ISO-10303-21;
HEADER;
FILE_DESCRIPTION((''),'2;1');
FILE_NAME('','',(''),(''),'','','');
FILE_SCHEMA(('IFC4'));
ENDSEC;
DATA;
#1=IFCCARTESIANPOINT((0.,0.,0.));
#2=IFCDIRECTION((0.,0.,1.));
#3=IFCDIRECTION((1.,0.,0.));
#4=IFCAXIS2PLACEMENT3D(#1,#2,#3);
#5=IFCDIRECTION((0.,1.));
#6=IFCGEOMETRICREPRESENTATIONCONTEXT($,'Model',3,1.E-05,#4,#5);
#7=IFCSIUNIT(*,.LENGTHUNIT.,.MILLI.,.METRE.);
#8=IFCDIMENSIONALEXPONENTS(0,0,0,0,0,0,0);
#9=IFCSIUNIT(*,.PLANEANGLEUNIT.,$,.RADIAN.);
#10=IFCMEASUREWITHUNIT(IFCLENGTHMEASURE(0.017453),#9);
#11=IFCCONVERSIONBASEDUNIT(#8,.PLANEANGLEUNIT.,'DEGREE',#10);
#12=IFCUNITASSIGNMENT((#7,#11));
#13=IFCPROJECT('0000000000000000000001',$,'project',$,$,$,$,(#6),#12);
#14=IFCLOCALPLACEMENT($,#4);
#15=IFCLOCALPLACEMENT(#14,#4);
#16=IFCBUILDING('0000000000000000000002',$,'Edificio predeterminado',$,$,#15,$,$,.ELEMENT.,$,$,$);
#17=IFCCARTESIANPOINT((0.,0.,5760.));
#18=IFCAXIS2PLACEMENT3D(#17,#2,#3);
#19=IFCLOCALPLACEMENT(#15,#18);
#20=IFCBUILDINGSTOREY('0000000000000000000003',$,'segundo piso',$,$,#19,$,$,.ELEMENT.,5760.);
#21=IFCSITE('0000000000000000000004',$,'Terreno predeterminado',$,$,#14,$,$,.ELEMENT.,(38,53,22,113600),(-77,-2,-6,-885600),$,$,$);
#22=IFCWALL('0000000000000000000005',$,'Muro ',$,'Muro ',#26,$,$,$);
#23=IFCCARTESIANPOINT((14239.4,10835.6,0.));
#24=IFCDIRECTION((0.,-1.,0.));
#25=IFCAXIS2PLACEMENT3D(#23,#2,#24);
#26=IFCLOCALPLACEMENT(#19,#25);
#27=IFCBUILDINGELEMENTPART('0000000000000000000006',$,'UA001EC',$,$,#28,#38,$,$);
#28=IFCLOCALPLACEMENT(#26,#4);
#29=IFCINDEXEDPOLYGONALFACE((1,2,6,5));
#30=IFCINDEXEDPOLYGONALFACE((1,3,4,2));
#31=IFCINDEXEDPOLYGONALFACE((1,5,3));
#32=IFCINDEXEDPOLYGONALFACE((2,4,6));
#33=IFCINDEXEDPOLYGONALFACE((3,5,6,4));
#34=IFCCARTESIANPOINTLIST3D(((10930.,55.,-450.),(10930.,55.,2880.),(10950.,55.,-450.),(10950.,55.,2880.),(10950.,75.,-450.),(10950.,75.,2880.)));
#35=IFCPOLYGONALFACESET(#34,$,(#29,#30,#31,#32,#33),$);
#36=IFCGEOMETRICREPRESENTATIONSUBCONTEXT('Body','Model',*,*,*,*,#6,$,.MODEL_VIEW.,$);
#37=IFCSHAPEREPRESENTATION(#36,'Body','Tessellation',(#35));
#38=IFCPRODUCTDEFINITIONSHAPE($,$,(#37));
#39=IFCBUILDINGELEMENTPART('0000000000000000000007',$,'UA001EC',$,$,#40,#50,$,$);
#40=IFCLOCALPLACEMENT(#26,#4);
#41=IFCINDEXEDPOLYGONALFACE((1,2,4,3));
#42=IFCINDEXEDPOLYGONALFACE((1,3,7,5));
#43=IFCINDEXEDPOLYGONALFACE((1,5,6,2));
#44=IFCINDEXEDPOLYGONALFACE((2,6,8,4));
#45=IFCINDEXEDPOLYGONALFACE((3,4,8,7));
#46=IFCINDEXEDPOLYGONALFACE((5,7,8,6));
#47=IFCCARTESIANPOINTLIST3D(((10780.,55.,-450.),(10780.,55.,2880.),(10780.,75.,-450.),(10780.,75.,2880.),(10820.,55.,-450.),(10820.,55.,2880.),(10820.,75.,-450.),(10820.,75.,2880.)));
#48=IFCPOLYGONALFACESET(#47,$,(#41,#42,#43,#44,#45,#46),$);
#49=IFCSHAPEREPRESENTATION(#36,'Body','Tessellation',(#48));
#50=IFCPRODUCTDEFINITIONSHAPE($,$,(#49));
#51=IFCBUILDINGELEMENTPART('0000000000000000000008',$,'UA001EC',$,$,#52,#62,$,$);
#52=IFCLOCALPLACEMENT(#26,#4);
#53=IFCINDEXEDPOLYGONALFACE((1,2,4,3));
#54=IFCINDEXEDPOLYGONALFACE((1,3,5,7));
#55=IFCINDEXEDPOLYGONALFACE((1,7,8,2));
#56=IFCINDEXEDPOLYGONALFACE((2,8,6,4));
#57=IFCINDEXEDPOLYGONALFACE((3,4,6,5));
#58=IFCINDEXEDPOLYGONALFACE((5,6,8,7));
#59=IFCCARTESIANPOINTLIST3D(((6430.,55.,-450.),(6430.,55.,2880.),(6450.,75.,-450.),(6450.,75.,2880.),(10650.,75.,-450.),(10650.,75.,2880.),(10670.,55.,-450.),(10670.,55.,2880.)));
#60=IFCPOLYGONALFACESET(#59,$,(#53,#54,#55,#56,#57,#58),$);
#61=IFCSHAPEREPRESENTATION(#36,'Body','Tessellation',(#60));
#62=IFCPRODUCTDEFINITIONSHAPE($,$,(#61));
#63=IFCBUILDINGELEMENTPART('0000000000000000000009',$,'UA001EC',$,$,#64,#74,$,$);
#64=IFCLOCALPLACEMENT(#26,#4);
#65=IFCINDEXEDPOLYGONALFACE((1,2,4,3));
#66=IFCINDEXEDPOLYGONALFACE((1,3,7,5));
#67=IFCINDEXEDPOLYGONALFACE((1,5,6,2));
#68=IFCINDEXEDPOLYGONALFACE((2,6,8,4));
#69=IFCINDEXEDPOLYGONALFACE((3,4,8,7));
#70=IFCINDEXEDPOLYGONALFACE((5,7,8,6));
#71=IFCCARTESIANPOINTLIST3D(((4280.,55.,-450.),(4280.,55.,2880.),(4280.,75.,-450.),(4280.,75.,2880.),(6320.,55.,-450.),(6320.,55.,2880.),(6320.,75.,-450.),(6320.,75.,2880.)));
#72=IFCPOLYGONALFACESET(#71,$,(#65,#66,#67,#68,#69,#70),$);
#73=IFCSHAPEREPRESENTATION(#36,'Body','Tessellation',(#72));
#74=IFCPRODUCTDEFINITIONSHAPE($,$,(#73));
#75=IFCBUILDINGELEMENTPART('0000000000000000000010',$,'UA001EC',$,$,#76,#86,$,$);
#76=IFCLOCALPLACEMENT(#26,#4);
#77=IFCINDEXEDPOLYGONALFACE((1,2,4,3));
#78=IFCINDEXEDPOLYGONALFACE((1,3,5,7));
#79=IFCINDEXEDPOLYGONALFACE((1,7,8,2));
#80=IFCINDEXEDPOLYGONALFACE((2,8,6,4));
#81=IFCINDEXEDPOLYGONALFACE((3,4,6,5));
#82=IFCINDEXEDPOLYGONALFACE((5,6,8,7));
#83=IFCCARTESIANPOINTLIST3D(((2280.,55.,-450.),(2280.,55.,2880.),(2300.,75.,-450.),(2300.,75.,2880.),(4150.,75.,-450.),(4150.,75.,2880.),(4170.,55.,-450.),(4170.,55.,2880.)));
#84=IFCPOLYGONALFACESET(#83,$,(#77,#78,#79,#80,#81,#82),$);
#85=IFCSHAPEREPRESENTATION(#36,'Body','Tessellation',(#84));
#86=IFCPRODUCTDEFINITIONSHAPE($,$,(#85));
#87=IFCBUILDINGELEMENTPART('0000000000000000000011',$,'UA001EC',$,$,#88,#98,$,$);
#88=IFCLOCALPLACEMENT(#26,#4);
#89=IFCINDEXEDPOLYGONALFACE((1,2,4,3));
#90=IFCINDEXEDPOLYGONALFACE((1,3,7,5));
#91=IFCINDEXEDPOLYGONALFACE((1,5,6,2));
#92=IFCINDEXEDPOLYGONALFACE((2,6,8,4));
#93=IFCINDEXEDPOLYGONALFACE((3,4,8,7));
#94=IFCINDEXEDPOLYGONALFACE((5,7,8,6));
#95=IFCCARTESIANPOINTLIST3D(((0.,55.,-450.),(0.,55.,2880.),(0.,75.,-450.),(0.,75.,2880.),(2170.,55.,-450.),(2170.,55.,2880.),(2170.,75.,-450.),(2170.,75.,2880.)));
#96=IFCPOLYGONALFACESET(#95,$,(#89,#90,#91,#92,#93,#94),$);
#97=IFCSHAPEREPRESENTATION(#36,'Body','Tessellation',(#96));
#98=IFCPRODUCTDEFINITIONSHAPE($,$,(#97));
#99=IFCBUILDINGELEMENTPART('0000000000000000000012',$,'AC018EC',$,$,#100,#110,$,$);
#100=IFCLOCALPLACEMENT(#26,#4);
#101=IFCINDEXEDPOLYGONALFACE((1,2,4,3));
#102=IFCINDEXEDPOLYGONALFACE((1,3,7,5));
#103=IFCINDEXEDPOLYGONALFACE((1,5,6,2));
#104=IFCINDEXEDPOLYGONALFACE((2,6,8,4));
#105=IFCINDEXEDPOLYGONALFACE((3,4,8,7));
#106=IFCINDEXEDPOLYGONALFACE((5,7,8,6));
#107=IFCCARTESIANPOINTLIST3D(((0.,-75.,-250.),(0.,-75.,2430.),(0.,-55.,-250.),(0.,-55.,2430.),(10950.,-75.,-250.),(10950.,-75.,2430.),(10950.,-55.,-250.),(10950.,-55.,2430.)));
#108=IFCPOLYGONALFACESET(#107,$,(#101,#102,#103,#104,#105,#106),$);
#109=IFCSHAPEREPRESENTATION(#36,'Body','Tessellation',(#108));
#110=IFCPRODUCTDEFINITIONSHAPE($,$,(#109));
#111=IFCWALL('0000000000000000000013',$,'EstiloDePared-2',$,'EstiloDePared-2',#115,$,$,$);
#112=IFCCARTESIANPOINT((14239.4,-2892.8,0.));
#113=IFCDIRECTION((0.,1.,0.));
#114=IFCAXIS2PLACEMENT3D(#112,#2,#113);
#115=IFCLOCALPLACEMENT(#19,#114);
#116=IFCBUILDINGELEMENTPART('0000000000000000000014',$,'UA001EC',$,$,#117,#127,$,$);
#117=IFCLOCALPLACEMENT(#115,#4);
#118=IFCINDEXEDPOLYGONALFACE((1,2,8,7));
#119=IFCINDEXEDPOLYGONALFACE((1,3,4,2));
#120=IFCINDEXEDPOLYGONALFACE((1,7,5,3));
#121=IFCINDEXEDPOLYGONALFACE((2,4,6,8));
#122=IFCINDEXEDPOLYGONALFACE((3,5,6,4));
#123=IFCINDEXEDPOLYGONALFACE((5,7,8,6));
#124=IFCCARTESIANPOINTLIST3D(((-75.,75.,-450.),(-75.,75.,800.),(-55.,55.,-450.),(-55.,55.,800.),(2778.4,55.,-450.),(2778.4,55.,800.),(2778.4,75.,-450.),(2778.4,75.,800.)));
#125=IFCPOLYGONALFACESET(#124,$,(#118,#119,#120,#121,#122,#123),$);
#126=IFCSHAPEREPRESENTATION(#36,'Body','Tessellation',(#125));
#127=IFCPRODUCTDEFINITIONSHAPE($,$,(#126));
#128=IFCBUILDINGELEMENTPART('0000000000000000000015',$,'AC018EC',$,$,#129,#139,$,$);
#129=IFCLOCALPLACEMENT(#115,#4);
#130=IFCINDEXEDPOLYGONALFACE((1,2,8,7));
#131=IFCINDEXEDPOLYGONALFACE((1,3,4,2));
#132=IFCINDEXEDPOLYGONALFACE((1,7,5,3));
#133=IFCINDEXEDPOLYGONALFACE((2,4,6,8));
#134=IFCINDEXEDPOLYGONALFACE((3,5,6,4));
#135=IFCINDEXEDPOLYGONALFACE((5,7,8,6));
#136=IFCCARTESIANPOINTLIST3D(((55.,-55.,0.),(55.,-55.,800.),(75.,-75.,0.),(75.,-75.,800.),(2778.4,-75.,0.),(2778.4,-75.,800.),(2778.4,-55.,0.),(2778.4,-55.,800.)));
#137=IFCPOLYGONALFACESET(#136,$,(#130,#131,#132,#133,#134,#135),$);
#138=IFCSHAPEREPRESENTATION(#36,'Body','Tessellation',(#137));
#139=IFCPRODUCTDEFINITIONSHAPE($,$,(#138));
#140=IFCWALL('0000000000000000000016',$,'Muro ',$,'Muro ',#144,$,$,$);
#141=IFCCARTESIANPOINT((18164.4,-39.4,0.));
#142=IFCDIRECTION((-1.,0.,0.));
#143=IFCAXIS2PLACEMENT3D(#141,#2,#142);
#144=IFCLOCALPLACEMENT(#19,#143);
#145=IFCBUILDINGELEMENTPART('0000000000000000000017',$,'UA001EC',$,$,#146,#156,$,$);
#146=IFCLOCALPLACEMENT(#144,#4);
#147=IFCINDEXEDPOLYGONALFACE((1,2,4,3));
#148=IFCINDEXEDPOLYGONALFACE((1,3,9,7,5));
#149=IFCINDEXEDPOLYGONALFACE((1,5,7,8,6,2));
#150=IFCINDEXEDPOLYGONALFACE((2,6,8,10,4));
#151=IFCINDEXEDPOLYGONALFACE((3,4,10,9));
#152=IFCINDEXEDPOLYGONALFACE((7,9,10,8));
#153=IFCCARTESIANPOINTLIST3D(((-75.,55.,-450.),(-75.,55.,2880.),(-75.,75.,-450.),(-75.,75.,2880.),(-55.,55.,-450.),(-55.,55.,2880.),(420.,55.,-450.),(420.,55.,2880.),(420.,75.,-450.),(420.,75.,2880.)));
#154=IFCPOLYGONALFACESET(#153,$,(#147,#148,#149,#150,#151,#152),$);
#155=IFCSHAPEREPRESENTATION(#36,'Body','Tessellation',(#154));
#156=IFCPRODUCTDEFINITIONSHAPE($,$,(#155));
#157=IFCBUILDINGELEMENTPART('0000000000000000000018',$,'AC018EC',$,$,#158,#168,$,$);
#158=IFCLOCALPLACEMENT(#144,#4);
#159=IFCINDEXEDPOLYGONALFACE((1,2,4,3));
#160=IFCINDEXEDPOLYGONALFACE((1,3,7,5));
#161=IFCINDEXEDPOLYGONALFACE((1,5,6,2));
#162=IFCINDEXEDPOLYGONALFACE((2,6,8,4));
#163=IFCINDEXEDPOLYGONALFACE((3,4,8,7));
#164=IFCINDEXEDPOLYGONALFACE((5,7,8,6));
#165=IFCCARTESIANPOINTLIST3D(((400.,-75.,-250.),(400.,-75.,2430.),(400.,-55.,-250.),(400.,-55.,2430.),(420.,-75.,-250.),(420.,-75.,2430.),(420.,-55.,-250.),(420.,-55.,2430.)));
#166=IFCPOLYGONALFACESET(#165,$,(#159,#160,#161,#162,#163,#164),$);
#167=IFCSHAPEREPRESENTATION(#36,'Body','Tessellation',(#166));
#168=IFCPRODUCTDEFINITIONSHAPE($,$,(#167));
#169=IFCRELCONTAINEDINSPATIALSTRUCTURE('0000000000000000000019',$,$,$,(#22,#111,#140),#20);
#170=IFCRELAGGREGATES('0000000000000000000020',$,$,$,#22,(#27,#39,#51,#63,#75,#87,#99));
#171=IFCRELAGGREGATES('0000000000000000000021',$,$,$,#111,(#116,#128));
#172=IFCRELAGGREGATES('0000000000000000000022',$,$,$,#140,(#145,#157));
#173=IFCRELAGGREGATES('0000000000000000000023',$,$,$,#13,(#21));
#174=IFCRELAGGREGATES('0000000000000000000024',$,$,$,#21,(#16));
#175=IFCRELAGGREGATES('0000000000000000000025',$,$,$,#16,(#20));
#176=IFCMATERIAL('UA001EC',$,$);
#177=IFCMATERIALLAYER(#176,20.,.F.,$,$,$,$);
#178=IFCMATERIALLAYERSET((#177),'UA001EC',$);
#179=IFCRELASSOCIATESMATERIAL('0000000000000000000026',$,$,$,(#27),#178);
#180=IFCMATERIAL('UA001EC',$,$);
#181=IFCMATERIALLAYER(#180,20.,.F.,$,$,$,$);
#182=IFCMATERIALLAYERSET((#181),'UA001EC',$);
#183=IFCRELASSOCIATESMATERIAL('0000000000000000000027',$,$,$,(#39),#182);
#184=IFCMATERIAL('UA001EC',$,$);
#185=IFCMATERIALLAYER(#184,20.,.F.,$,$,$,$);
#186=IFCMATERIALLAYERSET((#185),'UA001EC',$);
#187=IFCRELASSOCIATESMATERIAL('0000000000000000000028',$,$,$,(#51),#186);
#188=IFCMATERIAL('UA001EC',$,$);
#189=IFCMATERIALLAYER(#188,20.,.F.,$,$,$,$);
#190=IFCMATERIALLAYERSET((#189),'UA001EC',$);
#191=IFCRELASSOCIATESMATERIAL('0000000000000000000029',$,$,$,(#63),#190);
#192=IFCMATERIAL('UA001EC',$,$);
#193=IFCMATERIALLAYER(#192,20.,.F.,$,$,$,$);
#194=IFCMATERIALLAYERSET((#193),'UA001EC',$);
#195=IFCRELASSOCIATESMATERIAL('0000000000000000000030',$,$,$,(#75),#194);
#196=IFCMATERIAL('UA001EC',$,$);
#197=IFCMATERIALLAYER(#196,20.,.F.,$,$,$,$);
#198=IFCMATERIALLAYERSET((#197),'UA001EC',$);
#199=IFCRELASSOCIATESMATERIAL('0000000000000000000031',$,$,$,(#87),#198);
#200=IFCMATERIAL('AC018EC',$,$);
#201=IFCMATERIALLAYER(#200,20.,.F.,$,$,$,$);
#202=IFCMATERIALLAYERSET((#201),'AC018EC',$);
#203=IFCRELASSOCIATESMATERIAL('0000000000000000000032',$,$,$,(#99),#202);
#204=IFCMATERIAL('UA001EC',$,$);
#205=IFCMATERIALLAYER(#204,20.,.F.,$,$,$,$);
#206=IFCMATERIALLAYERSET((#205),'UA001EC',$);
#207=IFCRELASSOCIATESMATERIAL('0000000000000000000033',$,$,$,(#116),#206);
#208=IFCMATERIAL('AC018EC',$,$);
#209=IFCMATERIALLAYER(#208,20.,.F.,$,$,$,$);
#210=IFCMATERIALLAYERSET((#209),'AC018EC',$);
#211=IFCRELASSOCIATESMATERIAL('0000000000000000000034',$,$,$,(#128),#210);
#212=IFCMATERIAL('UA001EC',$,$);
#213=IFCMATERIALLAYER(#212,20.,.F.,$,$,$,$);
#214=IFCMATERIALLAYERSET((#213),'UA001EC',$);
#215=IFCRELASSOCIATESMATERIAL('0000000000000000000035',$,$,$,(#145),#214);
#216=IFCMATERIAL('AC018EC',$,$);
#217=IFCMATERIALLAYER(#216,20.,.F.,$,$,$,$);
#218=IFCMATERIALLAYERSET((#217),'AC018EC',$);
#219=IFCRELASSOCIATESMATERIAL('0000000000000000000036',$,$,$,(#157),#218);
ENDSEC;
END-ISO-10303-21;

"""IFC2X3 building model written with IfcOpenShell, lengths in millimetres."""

from ifc_helpers import new_model, entity, si_unit, converted_unit, direction, frame, origin_with_axes, place, context, subcontext, project, spatial, polyline, outline, extrude, material, layer, layer_set, layer_usage, element, aggregate, save


model = new_model("IFC2X3")

# Units and contexts
model_context = context("Model", 3, precision=1e-05, world=origin_with_axes(), true_north=direction((0.0, 1.0)))
body_context = subcontext(model_context, "Body", "Model", "MODEL_VIEW")
ifc_project = project(units=[si_unit("LENGTHUNIT", "METRE", prefix="MILLI"), converted_unit("PLANEANGLEUNIT", "DEGREE", entity("IfcLengthMeasure", 0.017453), si_unit("PLANEANGLEUNIT", "RADIAN"), dimensions=[0, 0, 0, 0, 0, 0, 0])], contexts=[model_context])

# Site, building, storey
site_placement = place(None, origin_with_axes())
site = spatial("IfcSite", under=ifc_project, at=site_placement, Name="Terreno predeterminado", CompositionType="ELEMENT", RefLatitude=(38, 53, 22, 113600), RefLongitude=(-77, -2, -6, -885600))
building_placement = place(site_placement, origin_with_axes())
building = spatial("IfcBuilding", under=site, at=building_placement, Name="Edificio predeterminado", CompositionType="ELEMENT")
storey_placement = place(building_placement, frame((0.0, 0.0, 5760.0), z_axis=(0.0, 0.0, 1.0), x_axis=(1.0, 0.0, 0.0)))
storey = spatial("IfcBuildingStorey", under=building, at=storey_placement, Name="segundo piso", CompositionType="ELEMENT", Elevation=5760.0)

# Walls, building element parts
wall_1_placement = place(storey_placement, frame((14239.4, 10835.6, 0.0), z_axis=(0.0, 0.0, 1.0), x_axis=(0.0, -1.0, 0.0)))
wall_1 = element("IfcWall", 1, at=wall_1_placement, inside=storey, Name="Muro ", ObjectType="Muro ")
ifc_material_1 = material(Name="UA001EC")
ifc_layer_1 = layer(ifc_material_1, 20.0, ventilated=False)
ifc_layer_set_1 = layer_set([ifc_layer_1], Name="UA001EC")
ifc_layer_usage_1 = layer_usage(ifc_layer_set_1, "AXIS2", "NEGATIVE", -75.0)
building_element_part_1_placement = place(wall_1_placement, origin_with_axes())
building_element_part_1 = element("IfcBuildingElementPart", 2, at=building_element_part_1_placement, material=ifc_layer_usage_1, Name="UA001EC", context=body_context, shape_type="SweptSolid", body=[
    extrude(outline(polyline([(10950.0, 75.0), (10950.0, 55.0), (10930.0, 55.0), (10950.0, 75.0)])), frame((0.0, 0.0, -450.0), z_axis=(0.0, 0.0, 1.0), x_axis=(1.0, 0.0, 0.0)), (0.0, 0.0, 1.0), 3330.0),
])
ifc_material_2 = material(Name="UA001EC")
ifc_layer_2 = layer(ifc_material_2, 20.0, ventilated=False)
ifc_layer_set_2 = layer_set([ifc_layer_2], Name="UA001EC")
ifc_layer_usage_2 = layer_usage(ifc_layer_set_2, "AXIS2", "NEGATIVE", -75.0)
building_element_part_2_placement = place(wall_1_placement, origin_with_axes())
building_element_part_2 = element("IfcBuildingElementPart", 3, at=building_element_part_2_placement, material=ifc_layer_usage_2, Name="UA001EC", context=body_context, shape_type="SweptSolid", body=[
    extrude(outline(polyline([(10820.0, 75.0), (10820.0, 55.0), (10780.0, 55.0), (10780.0, 75.0), (10820.0, 75.0)])), frame((0.0, 0.0, -450.0), z_axis=(0.0, 0.0, 1.0), x_axis=(1.0, 0.0, 0.0)), (0.0, 0.0, 1.0), 3330.0),
])
ifc_material_3 = material(Name="UA001EC")
ifc_layer_3 = layer(ifc_material_3, 20.0, ventilated=False)
ifc_layer_set_3 = layer_set([ifc_layer_3], Name="UA001EC")
ifc_layer_usage_3 = layer_usage(ifc_layer_set_3, "AXIS2", "NEGATIVE", -75.0)
building_element_part_3_placement = place(wall_1_placement, origin_with_axes())
building_element_part_3 = element("IfcBuildingElementPart", 4, at=building_element_part_3_placement, material=ifc_layer_usage_3, Name="UA001EC", context=body_context, shape_type="SweptSolid", body=[
    extrude(outline(polyline([(10650.0, 75.0), (10670.0, 55.0), (6430.0, 55.0), (6450.0, 75.0), (10650.0, 75.0)])), frame((0.0, 0.0, -450.0), z_axis=(0.0, 0.0, 1.0), x_axis=(1.0, 0.0, 0.0)), (0.0, 0.0, 1.0), 3330.0),
])
ifc_material_4 = material(Name="UA001EC")
ifc_layer_4 = layer(ifc_material_4, 20.0, ventilated=False)
ifc_layer_set_4 = layer_set([ifc_layer_4], Name="UA001EC")
ifc_layer_usage_4 = layer_usage(ifc_layer_set_4, "AXIS2", "NEGATIVE", -75.0)
building_element_part_4_placement = place(wall_1_placement, origin_with_axes())
building_element_part_4 = element("IfcBuildingElementPart", 5, at=building_element_part_4_placement, material=ifc_layer_usage_4, Name="UA001EC", context=body_context, shape_type="SweptSolid", body=[
    extrude(outline(polyline([(4280.0, 75.0), (6320.0, 75.0), (6320.0, 55.0), (4280.0, 55.0), (4280.0, 75.0)])), frame((0.0, 0.0, -450.0), z_axis=(0.0, 0.0, 1.0), x_axis=(1.0, 0.0, 0.0)), (0.0, 0.0, 1.0), 3330.0),
])
ifc_material_5 = material(Name="UA001EC")
ifc_layer_5 = layer(ifc_material_5, 20.0, ventilated=False)
ifc_layer_set_5 = layer_set([ifc_layer_5], Name="UA001EC")
ifc_layer_usage_5 = layer_usage(ifc_layer_set_5, "AXIS2", "NEGATIVE", -75.0)
building_element_part_5_placement = place(wall_1_placement, origin_with_axes())
building_element_part_5 = element("IfcBuildingElementPart", 6, at=building_element_part_5_placement, material=ifc_layer_usage_5, Name="UA001EC", context=body_context, shape_type="SweptSolid", body=[
    extrude(outline(polyline([(4150.0, 75.0), (4170.0, 55.0), (2280.0, 55.0), (2300.0, 75.0), (4150.0, 75.0)])), frame((0.0, 0.0, -450.0), z_axis=(0.0, 0.0, 1.0), x_axis=(1.0, 0.0, 0.0)), (0.0, 0.0, 1.0), 3330.0),
])
ifc_material_6 = material(Name="UA001EC")
ifc_layer_6 = layer(ifc_material_6, 20.0, ventilated=False)
ifc_layer_set_6 = layer_set([ifc_layer_6], Name="UA001EC")
ifc_layer_usage_6 = layer_usage(ifc_layer_set_6, "AXIS2", "NEGATIVE", -75.0)
building_element_part_6_placement = place(wall_1_placement, origin_with_axes())
building_element_part_6 = element("IfcBuildingElementPart", 7, at=building_element_part_6_placement, material=ifc_layer_usage_6, Name="UA001EC", context=body_context, shape_type="SweptSolid", body=[
    extrude(outline(polyline([(2170.0, 75.0), (2170.0, 55.0), (0.0, 55.0), (0.0, 75.0), (2170.0, 75.0)])), frame((0.0, 0.0, -450.0), z_axis=(0.0, 0.0, 1.0), x_axis=(1.0, 0.0, 0.0)), (0.0, 0.0, 1.0), 3330.0),
])
ifc_material_7 = material(Name="AC018EC")
ifc_layer_7 = layer(ifc_material_7, 20.0, ventilated=False)
ifc_layer_set_7 = layer_set([ifc_layer_7], Name="AC018EC")
ifc_layer_usage_7 = layer_usage(ifc_layer_set_7, "AXIS2", "NEGATIVE", 55.0)
building_element_part_7_placement = place(wall_1_placement, origin_with_axes())
building_element_part_7 = element("IfcBuildingElementPart", 8, at=building_element_part_7_placement, material=ifc_layer_usage_7, Name="AC018EC", context=body_context, shape_type="SweptSolid", body=[
    extrude(outline(polyline([(10950.0, -55.0), (10950.0, -75.0), (0.0, -75.0), (0.0, -55.0), (10950.0, -55.0)])), frame((0.0, 0.0, -250.0), z_axis=(0.0, 0.0, 1.0), x_axis=(1.0, 0.0, 0.0)), (0.0, 0.0, 1.0), 2680.0),
])
aggregate(wall_1, [building_element_part_1, building_element_part_2, building_element_part_3, building_element_part_4, building_element_part_5, building_element_part_6, building_element_part_7])
wall_2_placement = place(storey_placement, frame((14239.4, -2892.8, 0.0), z_axis=(0.0, 0.0, 1.0), x_axis=(0.0, 1.0, 0.0)))
wall_2 = element("IfcWall", 9, at=wall_2_placement, inside=storey, Name="EstiloDePared-2", ObjectType="EstiloDePared-2")
ifc_material_8 = material(Name="UA001EC")
ifc_layer_8 = layer(ifc_material_8, 20.0, ventilated=False)
ifc_layer_set_8 = layer_set([ifc_layer_8], Name="UA001EC")
ifc_layer_usage_8 = layer_usage(ifc_layer_set_8, "AXIS2", "NEGATIVE", -75.0)
building_element_part_8_placement = place(wall_2_placement, origin_with_axes())
building_element_part_8 = element("IfcBuildingElementPart", 10, at=building_element_part_8_placement, material=ifc_layer_usage_8, Name="UA001EC", context=body_context, shape_type="SweptSolid", body=[
    extrude(outline(polyline([(2778.4, 75.0), (2778.4, 55.0), (-55.0, 55.0), (-75.0, 75.0), (2778.4, 75.0)])), frame((0.0, 0.0, -450.0), z_axis=(0.0, 0.0, 1.0), x_axis=(1.0, 0.0, 0.0)), (0.0, 0.0, 1.0), 1250.0),
])
ifc_material_9 = material(Name="AC018EC")
ifc_layer_9 = layer(ifc_material_9, 20.0, ventilated=False)
ifc_layer_set_9 = layer_set([ifc_layer_9], Name="AC018EC")
ifc_layer_usage_9 = layer_usage(ifc_layer_set_9, "AXIS2", "NEGATIVE", 55.0)
building_element_part_9_placement = place(wall_2_placement, origin_with_axes())
building_element_part_9 = element("IfcBuildingElementPart", 11, at=building_element_part_9_placement, material=ifc_layer_usage_9, Name="AC018EC", context=body_context, shape_type="SweptSolid", body=[
    extrude(outline(polyline([(2778.4, -55.0), (2778.4, -75.0), (75.0, -75.0), (55.0, -55.0), (2778.4, -55.0)])), origin_with_axes(), (0.0, 0.0, 1.0), 800.0),
])
aggregate(wall_2, [building_element_part_8, building_element_part_9])
wall_3_placement = place(storey_placement, frame((18164.4, -39.4, 0.0), z_axis=(0.0, 0.0, 1.0), x_axis=(-1.0, 0.0, 0.0)))
wall_3 = element("IfcWall", 12, at=wall_3_placement, inside=storey, Name="Muro ", ObjectType="Muro ")
ifc_material_10 = material(Name="UA001EC")
ifc_layer_10 = layer(ifc_material_10, 20.0, ventilated=False)
ifc_layer_set_10 = layer_set([ifc_layer_10], Name="UA001EC")
ifc_layer_usage_10 = layer_usage(ifc_layer_set_10, "AXIS2", "NEGATIVE", -75.0)
building_element_part_10_placement = place(wall_3_placement, origin_with_axes())
building_element_part_10 = element("IfcBuildingElementPart", 13, at=building_element_part_10_placement, material=ifc_layer_usage_10, Name="UA001EC", context=body_context, shape_type="SweptSolid", body=[
    extrude(outline(polyline([(420.0, 75.0), (420.0, 55.0), (-55.0, 55.0), (-75.0, 55.0), (-75.0, 75.0), (420.0, 75.0)])), frame((0.0, 0.0, -450.0), z_axis=(0.0, 0.0, 1.0), x_axis=(1.0, 0.0, 0.0)), (0.0, 0.0, 1.0), 3330.0),
])
ifc_material_11 = material(Name="AC018EC")
ifc_layer_11 = layer(ifc_material_11, 20.0, ventilated=False)
ifc_layer_set_11 = layer_set([ifc_layer_11], Name="AC018EC")
ifc_layer_usage_11 = layer_usage(ifc_layer_set_11, "AXIS2", "NEGATIVE", 55.0)
building_element_part_11_placement = place(wall_3_placement, origin_with_axes())
building_element_part_11 = element("IfcBuildingElementPart", 14, at=building_element_part_11_placement, material=ifc_layer_usage_11, Name="AC018EC", context=body_context, shape_type="SweptSolid", body=[
    extrude(outline(polyline([(420.0, -55.0), (420.0, -75.0), (400.0, -75.0), (400.0, -55.0), (420.0, -55.0)])), frame((0.0, 0.0, -250.0), z_axis=(0.0, 0.0, 1.0), x_axis=(1.0, 0.0, 0.0)), (0.0, 0.0, 1.0), 2680.0),
])
aggregate(wall_3, [building_element_part_10, building_element_part_11])

save(model, "model.ifc")
